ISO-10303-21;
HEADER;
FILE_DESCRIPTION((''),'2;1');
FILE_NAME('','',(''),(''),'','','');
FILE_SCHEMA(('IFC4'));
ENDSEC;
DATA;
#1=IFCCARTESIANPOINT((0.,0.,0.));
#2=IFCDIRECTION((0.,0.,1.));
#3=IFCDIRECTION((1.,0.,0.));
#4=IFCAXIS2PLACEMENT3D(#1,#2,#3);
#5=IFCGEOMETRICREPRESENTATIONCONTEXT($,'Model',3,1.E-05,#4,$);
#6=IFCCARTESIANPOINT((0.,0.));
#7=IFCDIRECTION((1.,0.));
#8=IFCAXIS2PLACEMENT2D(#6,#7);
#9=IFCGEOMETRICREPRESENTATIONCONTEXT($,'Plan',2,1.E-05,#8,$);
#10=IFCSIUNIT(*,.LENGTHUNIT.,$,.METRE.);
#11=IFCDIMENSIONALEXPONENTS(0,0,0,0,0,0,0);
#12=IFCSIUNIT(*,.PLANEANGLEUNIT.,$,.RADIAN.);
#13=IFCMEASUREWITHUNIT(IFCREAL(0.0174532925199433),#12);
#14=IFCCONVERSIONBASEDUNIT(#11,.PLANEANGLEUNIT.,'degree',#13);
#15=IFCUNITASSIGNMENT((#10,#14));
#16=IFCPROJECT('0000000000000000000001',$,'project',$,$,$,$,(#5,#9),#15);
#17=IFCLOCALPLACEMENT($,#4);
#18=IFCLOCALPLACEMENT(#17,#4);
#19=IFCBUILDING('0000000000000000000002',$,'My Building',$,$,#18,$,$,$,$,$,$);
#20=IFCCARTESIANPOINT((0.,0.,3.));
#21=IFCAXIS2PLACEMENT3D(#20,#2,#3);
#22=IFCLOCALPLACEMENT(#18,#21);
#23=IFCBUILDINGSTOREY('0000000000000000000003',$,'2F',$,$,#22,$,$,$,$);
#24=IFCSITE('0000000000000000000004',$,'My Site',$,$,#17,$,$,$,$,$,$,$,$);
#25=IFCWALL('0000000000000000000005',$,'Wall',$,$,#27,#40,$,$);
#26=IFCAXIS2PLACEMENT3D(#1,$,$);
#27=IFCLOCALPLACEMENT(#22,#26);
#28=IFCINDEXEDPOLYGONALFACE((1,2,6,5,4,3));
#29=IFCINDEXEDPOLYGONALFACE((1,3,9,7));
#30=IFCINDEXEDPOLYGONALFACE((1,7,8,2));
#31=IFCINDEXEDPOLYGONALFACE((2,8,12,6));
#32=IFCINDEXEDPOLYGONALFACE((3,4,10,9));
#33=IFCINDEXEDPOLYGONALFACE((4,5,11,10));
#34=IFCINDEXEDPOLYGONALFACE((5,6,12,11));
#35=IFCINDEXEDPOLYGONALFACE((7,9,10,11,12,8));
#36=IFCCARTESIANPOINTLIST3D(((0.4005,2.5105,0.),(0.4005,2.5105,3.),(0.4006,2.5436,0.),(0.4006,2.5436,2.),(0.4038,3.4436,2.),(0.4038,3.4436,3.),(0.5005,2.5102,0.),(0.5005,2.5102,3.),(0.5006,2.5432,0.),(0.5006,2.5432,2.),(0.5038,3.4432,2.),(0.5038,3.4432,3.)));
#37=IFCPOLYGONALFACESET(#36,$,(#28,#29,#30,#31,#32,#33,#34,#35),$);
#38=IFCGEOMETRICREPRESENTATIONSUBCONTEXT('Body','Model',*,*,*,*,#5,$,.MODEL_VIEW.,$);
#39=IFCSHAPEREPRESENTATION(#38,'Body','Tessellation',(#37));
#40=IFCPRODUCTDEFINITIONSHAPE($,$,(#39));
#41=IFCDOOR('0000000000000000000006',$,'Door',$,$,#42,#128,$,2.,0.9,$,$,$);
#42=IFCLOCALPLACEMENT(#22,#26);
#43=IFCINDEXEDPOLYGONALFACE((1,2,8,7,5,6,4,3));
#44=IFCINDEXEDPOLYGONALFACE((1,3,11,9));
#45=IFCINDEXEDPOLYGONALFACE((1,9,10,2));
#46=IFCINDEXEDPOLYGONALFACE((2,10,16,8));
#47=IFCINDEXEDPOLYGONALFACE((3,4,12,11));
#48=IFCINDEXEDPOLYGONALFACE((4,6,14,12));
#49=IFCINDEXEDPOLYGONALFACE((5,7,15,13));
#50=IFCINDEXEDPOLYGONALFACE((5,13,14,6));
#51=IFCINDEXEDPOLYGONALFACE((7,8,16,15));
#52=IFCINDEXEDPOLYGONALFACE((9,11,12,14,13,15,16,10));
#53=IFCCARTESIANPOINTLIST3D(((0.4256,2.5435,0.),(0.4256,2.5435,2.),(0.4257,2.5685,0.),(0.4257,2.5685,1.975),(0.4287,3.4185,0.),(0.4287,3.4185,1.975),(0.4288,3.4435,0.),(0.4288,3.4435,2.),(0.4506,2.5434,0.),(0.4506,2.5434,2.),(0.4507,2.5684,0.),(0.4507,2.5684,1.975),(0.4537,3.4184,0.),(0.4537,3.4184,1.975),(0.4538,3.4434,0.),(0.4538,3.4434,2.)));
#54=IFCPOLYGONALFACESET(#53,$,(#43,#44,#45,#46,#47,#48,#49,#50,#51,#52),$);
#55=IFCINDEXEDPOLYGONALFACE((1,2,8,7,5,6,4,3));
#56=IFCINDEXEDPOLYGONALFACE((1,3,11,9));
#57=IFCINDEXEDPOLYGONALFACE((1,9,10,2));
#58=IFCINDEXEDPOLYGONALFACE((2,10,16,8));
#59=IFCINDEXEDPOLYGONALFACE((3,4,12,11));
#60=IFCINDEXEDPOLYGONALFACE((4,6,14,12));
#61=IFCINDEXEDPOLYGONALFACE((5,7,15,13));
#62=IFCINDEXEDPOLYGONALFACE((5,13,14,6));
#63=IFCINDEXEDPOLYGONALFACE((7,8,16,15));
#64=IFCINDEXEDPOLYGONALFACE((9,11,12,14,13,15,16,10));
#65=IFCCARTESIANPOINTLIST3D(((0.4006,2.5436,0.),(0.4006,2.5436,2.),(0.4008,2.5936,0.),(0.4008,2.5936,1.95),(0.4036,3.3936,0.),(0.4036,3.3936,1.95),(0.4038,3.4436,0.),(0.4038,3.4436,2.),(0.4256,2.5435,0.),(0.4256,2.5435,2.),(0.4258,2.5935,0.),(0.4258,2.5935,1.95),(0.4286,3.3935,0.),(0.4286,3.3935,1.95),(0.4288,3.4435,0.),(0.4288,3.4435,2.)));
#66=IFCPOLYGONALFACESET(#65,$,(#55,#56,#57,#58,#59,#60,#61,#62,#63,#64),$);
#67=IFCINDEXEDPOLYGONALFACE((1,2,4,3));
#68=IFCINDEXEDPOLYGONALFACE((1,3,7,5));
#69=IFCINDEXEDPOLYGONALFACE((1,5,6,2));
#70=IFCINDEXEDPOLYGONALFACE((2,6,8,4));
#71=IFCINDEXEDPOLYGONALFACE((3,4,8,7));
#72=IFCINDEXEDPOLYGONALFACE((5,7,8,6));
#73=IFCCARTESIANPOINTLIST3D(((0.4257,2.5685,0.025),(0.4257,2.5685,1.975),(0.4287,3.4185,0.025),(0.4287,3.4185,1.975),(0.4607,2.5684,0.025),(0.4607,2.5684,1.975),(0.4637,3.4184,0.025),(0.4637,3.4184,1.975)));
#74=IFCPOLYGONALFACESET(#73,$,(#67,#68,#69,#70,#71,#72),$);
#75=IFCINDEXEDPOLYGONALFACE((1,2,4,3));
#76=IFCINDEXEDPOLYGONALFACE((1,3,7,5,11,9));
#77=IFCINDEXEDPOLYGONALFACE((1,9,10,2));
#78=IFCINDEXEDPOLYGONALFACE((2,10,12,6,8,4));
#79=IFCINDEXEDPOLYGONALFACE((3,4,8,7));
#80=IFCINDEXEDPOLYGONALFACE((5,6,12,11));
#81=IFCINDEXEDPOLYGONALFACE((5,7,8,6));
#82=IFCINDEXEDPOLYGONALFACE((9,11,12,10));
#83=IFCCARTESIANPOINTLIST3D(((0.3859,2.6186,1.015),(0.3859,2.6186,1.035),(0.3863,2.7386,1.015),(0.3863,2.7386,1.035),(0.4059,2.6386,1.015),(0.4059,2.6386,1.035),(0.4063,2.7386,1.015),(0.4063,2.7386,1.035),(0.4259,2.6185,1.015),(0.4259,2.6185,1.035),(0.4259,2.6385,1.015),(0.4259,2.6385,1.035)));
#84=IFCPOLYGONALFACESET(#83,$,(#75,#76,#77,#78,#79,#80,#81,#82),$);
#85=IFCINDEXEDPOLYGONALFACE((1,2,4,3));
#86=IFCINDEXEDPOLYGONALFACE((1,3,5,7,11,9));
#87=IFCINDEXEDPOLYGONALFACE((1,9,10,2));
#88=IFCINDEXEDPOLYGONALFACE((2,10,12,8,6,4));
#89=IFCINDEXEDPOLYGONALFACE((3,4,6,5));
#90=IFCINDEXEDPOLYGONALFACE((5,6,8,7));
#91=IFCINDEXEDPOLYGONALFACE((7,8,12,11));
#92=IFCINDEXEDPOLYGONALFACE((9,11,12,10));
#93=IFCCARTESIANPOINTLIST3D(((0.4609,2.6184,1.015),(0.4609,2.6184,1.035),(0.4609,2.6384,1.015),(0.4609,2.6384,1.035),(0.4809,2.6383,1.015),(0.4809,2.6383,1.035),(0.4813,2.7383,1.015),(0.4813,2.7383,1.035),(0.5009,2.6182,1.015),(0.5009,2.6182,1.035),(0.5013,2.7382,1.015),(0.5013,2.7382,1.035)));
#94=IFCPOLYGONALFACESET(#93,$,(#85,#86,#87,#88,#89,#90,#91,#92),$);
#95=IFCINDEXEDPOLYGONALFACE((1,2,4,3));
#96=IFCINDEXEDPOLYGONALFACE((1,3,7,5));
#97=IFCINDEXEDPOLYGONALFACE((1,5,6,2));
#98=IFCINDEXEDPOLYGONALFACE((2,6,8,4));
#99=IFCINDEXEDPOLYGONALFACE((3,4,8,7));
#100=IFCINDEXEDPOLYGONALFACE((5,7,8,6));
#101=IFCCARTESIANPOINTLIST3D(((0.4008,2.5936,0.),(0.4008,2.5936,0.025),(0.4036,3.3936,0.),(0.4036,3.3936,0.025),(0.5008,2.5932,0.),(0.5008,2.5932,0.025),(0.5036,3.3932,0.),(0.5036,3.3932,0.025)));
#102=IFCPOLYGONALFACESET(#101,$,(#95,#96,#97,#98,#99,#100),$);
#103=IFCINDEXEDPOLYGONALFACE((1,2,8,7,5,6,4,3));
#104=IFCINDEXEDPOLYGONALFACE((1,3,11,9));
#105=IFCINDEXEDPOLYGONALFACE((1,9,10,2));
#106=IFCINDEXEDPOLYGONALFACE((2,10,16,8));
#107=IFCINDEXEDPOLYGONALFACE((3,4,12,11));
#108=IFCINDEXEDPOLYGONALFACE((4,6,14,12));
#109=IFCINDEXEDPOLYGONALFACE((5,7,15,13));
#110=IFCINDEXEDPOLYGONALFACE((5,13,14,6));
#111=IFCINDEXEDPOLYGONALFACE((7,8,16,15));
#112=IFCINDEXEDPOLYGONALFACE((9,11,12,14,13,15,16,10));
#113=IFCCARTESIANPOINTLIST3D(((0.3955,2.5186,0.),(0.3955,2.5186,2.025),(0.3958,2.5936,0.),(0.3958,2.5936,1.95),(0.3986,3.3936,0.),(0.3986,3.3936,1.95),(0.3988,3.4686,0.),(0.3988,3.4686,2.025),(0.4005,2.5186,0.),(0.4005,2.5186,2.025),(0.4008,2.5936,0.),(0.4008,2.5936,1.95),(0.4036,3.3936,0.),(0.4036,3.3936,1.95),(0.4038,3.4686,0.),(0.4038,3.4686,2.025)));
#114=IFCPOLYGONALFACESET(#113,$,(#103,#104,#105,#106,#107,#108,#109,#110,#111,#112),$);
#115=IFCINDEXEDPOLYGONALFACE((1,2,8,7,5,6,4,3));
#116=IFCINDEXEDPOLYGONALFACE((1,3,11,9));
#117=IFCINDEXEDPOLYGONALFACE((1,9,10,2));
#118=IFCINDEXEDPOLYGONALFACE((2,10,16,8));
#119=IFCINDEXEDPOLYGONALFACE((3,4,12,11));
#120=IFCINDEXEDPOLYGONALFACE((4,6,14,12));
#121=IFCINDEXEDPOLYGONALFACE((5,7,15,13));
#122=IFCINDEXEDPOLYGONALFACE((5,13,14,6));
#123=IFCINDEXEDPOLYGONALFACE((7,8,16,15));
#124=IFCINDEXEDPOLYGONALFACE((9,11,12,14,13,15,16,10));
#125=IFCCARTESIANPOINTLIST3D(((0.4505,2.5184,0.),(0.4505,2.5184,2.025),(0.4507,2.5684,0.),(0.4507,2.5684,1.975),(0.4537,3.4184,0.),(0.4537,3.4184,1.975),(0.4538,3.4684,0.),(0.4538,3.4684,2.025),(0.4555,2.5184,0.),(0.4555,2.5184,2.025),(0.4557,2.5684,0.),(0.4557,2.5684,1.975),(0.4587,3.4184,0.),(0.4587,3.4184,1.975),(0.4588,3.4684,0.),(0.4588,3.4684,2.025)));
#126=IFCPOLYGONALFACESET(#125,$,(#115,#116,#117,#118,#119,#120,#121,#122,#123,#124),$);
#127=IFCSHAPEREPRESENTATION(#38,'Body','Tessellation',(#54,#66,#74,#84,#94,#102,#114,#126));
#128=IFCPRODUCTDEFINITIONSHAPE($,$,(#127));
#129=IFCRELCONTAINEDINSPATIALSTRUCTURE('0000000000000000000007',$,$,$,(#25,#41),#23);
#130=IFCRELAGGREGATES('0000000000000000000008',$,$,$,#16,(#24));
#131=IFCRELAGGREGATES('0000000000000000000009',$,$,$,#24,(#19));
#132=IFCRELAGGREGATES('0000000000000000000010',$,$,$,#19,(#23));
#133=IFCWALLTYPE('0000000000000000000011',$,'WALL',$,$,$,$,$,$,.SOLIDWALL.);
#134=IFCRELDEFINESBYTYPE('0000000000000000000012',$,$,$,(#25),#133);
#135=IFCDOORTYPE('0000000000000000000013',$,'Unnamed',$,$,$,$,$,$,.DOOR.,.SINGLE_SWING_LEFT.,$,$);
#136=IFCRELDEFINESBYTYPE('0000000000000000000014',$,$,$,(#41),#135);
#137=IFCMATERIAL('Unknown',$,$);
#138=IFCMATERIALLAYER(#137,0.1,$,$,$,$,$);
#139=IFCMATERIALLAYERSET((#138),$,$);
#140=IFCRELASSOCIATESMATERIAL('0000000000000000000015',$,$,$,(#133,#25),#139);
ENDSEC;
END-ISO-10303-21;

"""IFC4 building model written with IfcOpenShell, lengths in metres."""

from ifc_helpers import new_model, entity, si_unit, converted_unit, frame, origin_with_axes, origin_2d_with_axis, place, context, subcontext, project, spatial, line, indexed_curve, outline, extrude, shape, source, transform, mapped, material, layer, layer_set, layer_usage, type_object, type_shapes, element, fill, save


model = new_model("IFC4")

# Units and contexts
model_context = context("Model", 3, precision=1e-05, world=origin_with_axes())
plan_context = context("Plan", 2, precision=1e-05, world=origin_2d_with_axis())
body_context_1 = subcontext(model_context, "Body", "Model", "MODEL_VIEW")
body_context_2 = subcontext(plan_context, "Body", "Plan", "PLAN_VIEW")
ifc_project = project(units=[si_unit("LENGTHUNIT", "METRE"), converted_unit("PLANEANGLEUNIT", "degree", entity("IfcReal", 0.0174532925199433), si_unit("PLANEANGLEUNIT", "RADIAN"), dimensions=[0, 0, 0, 0, 0, 0, 0])], contexts=[model_context, plan_context])

# Site, building, storey
site_placement = place(None, origin_with_axes())
site = spatial("IfcSite", under=ifc_project, at=site_placement, Name="My Site")
building_placement = place(site_placement, origin_with_axes())
building = spatial("IfcBuilding", under=site, at=building_placement, Name="My Building")
storey_placement = place(building_placement, frame((0.0, 0.0, 3.0), z_axis=(0.0, 0.0, 1.0), x_axis=(1.0, 0.0, 0.0)))
storey = spatial("IfcBuildingStorey", under=building, at=storey_placement, Name="2F")

# Shared definitions
ifc_material = material(Name="Unknown")

# Shared definitions
ifc_layer_1 = layer(ifc_material, 0.1)
ifc_layer_set_1 = layer_set([ifc_layer_1])
wall_type = type_object("IfcWallType", Name="WALL", PredefinedType="SOLIDWALL", material=ifc_layer_set_1)

# Shared definitions
shared_shape_1 = source(origin_with_axes(), body_context_1, "Body", "SweptSolid", [
    extrude(outline(indexed_curve([(0.0, 0.0), (0.9, 0.0), (0.9, 2.0), (0.0, 2.0)], segments=[line(1, 2, 3, 4, 1)])), frame((0.0, -0.6, 0.0), z_axis=(0.0, -1.0, 0.0), x_axis=(1.0, 0.0, 0.0)), (0.0, 0.0, -1.0), 1.2),
])
door_type = type_object("IfcDoorType", Name="Unnamed", OperationType="SINGLE_SWING_LEFT", PredefinedType="DOOR")
shared_shape_2 = source(origin_with_axes(), body_context_1, "Body", "SweptSolid", [
    extrude(outline(indexed_curve([(0.0, 0.0), (0.0, 2.0), (0.9, 2.0), (0.9, 0.0), (0.875, 0.0), (0.875, 1.975), (0.025, 1.975), (0.025, 0.0)], segments=[line(1, 2, 3, 4, 5, 6, 7, 8, 1)])), frame((0.0, 0.025, 0.0), z_axis=(0.0, -1.0, 0.0), x_axis=(1.0, 0.0, 0.0)), (0.0, 0.0, -1.0), 0.025),
    extrude(outline(indexed_curve([(0.0, 0.0), (0.0, 2.0), (0.9, 2.0), (0.9, 0.0), (0.85, 0.0), (0.85, 1.95), (0.05, 1.95), (0.05, 0.0)], segments=[line(1, 2, 3, 4, 5, 6, 7, 8, 1)])), frame((0.0, 0.0, 0.0), z_axis=(0.0, -1.0, 0.0), x_axis=(1.0, 0.0, 0.0)), (0.0, 0.0, -1.0), 0.025),
    extrude(outline(indexed_curve([(0.0, 0.0), (0.85, 0.0), (0.85, 0.035), (0.0, 0.035)], segments=[line(1, 2, 3, 4, 1)])), frame((0.025, 0.025, 0.025), z_axis=(0.0, 0.0, 1.0), x_axis=(1.0, 0.0, 0.0)), (0.0, 0.0, 1.0), 1.95),
    extrude(outline(indexed_curve([(0.0, 0.0), (0.0, -0.04), (-0.12, -0.04), (-0.12, -0.02), (-0.02, -0.02), (-0.02, 0.0)], segments=[line(1, 2, 3, 4, 5, 6, 1)])), frame((0.825, 0.025, 1.015), z_axis=(0.0, 0.0, 1.0), x_axis=(1.0, 0.0, 0.0)), (0.0, 0.0, 1.0), 0.02),
    extrude(outline(indexed_curve([(0.0, 0.0), (0.0, 0.04), (-0.12, 0.04), (-0.12, 0.02), (-0.02, 0.02), (-0.02, 0.0)], segments=[line(1, 2, 3, 4, 5, 6, 1)])), frame((0.825, 0.06, 1.015), z_axis=(0.0, 0.0, 1.0), x_axis=(1.0, 0.0, 0.0)), (0.0, 0.0, 1.0), 0.02),
    extrude(outline(indexed_curve([(0.0, 0.0), (0.8, 0.0), (0.8, 0.1), (0.0, 0.1)], segments=[line(1, 2, 3, 4, 1)])), frame((0.05, 0.0, 0.0), z_axis=(0.0, 0.0, 1.0), x_axis=(1.0, 0.0, 0.0)), (0.0, 0.0, 1.0), 0.025),
    extrude(outline(indexed_curve([(0.0, 0.0), (0.0, 2.025), (0.95, 2.025), (0.95, 0.0), (0.875, 0.0), (0.875, 1.95), (0.075, 1.95), (0.075, 0.0)], segments=[line(1, 2, 3, 4, 5, 6, 7, 8, 1)])), frame((-0.025, -0.005, 0.0), z_axis=(0.0, -1.0, 0.0), x_axis=(1.0, 0.0, 0.0)), (0.0, 0.0, -1.0), 0.005),
    extrude(outline(indexed_curve([(0.0, 0.0), (0.0, 2.025), (0.95, 2.025), (0.95, 0.0), (0.9, 0.0), (0.9, 1.975), (0.05, 1.975), (0.05, 0.0)], segments=[line(1, 2, 3, 4, 5, 6, 7, 8, 1)])), frame((-0.025, 0.05, 0.0), z_axis=(0.0, -1.0, 0.0), x_axis=(1.0, 0.0, 0.0)), (0.0, 0.0, -1.0), 0.005),
])
shared_shape_3 = source(origin_with_axes(), body_context_2, "Body", "Curve2D", [
    entity("IfcIndexedPolyCurve", entity("IfcCartesianPointList2D", [[0.0, 0.0], [0.0, 0.05], [0.025, 0.05], [0.025, 0.025], [0.05, 0.025], [0.05, 0.0]]), [entity("IfcLineIndex", [1, 2, 3, 4, 5, 6, 1])]),
    entity("IfcIndexedPolyCurve", entity("IfcCartesianPointList2D", [[0.9, 0.0], [0.9, 0.05], [0.875, 0.05], [0.875, 0.025], [0.85, 0.025], [0.85, 0.0]]), [entity("IfcLineIndex", [1, 2, 3, 4, 5, 6, 1])]),
    entity("IfcTrimmedCurve", entity("IfcEllipse", entity("IfcAxis2Placement2D", entity("IfcCartesianPoint", [0.06, 0.05]), entity("IfcDirection", [1.0, 0.0])), 0.815, 0.85), [entity("IfcCartesianPoint", [0.875, 0.05])], [entity("IfcCartesianPoint", [0.06, 0.9])], True, "CARTESIAN"),
    entity("IfcIndexedPolyCurve", entity("IfcCartesianPointList2D", [[0.025, 0.05], [0.06, 0.05], [0.06, 0.9], [0.025, 0.9]]), [entity("IfcLineIndex", [1, 2, 3, 4, 1])]),
])
type_shapes(door_type, [shared_shape_2, shared_shape_3])

# Wall, opening, door
ifc_layer_usage_1 = layer_usage(ifc_layer_set_1, "AXIS2", "POSITIVE", 0.0)
wall_1_placement = place(storey_placement, frame((0.4038, 3.4436, 0.0), z_axis=(0.0, 0.0, 1.0), x_axis=(-0.003501, -0.999994, 0.0)))
wall_1 = element("IfcWall", 1, at=wall_1_placement, inside=storey, type_object=wall_type, material=ifc_layer_usage_1, Name="Wall", context=body_context_1, shape_type="SweptSolid", body=[
    extrude(outline(indexed_curve([(0.0, 0.0), (0.0, 0.1), (0.933, 0.1), (0.933, 0.0)], segments=[line(1, 2, 3, 4, 1)])), origin_with_axes(), (0.0, 0.0, 1.0), 3.0),
])
opening_1_placement = place(wall_1_placement, frame((0.0, 0.0, 0.0), z_axis=(0.0, 0.0, 1.0), x_axis=(1.0, 0.0, 0.0)))
opening_1 = element("IfcOpeningElement", 2, at=opening_1_placement, cuts=wall_1, PredefinedType="OPENING", context=body_context_1, shape_type="MappedRepresentation", body=[
    mapped(shared_shape_1, transform((0.0, 0.0, 0.0), x_axis=(1.0, 0.0, 0.0), y_axis=(0.0, 1.0, 0.0), z_axis=(0.0, 0.0, 1.0), scale=1.0)),
])
door_1_placement = place(opening_1_placement, frame((0.0, 0.0, 0.0), z_axis=(0.0, 0.0, 1.0), x_axis=(1.0, 0.0, 0.0)))
door_1 = element("IfcDoor", 3, at=door_1_placement, inside=storey, type_object=door_type, Name="Door", OverallHeight=2.0, OverallWidth=0.9, shapes=[
    shape(body_context_1, "Body", "MappedRepresentation", [mapped(shared_shape_2, transform((0.0, 0.0, 0.0), x_axis=(1.0, 0.0, 0.0), y_axis=(0.0, 1.0, 0.0), z_axis=(0.0, 0.0, 1.0), scale=1.0))]),
    shape(body_context_2, "Body", "MappedRepresentation", [mapped(shared_shape_3, transform((0.0, 0.0, 0.0), x_axis=(1.0, 0.0, 0.0), y_axis=(0.0, 1.0, 0.0), z_axis=(0.0, 0.0, 1.0), scale=1.0))]),
])
fill(opening_1, door_1)

save(model, "model.ifc")
